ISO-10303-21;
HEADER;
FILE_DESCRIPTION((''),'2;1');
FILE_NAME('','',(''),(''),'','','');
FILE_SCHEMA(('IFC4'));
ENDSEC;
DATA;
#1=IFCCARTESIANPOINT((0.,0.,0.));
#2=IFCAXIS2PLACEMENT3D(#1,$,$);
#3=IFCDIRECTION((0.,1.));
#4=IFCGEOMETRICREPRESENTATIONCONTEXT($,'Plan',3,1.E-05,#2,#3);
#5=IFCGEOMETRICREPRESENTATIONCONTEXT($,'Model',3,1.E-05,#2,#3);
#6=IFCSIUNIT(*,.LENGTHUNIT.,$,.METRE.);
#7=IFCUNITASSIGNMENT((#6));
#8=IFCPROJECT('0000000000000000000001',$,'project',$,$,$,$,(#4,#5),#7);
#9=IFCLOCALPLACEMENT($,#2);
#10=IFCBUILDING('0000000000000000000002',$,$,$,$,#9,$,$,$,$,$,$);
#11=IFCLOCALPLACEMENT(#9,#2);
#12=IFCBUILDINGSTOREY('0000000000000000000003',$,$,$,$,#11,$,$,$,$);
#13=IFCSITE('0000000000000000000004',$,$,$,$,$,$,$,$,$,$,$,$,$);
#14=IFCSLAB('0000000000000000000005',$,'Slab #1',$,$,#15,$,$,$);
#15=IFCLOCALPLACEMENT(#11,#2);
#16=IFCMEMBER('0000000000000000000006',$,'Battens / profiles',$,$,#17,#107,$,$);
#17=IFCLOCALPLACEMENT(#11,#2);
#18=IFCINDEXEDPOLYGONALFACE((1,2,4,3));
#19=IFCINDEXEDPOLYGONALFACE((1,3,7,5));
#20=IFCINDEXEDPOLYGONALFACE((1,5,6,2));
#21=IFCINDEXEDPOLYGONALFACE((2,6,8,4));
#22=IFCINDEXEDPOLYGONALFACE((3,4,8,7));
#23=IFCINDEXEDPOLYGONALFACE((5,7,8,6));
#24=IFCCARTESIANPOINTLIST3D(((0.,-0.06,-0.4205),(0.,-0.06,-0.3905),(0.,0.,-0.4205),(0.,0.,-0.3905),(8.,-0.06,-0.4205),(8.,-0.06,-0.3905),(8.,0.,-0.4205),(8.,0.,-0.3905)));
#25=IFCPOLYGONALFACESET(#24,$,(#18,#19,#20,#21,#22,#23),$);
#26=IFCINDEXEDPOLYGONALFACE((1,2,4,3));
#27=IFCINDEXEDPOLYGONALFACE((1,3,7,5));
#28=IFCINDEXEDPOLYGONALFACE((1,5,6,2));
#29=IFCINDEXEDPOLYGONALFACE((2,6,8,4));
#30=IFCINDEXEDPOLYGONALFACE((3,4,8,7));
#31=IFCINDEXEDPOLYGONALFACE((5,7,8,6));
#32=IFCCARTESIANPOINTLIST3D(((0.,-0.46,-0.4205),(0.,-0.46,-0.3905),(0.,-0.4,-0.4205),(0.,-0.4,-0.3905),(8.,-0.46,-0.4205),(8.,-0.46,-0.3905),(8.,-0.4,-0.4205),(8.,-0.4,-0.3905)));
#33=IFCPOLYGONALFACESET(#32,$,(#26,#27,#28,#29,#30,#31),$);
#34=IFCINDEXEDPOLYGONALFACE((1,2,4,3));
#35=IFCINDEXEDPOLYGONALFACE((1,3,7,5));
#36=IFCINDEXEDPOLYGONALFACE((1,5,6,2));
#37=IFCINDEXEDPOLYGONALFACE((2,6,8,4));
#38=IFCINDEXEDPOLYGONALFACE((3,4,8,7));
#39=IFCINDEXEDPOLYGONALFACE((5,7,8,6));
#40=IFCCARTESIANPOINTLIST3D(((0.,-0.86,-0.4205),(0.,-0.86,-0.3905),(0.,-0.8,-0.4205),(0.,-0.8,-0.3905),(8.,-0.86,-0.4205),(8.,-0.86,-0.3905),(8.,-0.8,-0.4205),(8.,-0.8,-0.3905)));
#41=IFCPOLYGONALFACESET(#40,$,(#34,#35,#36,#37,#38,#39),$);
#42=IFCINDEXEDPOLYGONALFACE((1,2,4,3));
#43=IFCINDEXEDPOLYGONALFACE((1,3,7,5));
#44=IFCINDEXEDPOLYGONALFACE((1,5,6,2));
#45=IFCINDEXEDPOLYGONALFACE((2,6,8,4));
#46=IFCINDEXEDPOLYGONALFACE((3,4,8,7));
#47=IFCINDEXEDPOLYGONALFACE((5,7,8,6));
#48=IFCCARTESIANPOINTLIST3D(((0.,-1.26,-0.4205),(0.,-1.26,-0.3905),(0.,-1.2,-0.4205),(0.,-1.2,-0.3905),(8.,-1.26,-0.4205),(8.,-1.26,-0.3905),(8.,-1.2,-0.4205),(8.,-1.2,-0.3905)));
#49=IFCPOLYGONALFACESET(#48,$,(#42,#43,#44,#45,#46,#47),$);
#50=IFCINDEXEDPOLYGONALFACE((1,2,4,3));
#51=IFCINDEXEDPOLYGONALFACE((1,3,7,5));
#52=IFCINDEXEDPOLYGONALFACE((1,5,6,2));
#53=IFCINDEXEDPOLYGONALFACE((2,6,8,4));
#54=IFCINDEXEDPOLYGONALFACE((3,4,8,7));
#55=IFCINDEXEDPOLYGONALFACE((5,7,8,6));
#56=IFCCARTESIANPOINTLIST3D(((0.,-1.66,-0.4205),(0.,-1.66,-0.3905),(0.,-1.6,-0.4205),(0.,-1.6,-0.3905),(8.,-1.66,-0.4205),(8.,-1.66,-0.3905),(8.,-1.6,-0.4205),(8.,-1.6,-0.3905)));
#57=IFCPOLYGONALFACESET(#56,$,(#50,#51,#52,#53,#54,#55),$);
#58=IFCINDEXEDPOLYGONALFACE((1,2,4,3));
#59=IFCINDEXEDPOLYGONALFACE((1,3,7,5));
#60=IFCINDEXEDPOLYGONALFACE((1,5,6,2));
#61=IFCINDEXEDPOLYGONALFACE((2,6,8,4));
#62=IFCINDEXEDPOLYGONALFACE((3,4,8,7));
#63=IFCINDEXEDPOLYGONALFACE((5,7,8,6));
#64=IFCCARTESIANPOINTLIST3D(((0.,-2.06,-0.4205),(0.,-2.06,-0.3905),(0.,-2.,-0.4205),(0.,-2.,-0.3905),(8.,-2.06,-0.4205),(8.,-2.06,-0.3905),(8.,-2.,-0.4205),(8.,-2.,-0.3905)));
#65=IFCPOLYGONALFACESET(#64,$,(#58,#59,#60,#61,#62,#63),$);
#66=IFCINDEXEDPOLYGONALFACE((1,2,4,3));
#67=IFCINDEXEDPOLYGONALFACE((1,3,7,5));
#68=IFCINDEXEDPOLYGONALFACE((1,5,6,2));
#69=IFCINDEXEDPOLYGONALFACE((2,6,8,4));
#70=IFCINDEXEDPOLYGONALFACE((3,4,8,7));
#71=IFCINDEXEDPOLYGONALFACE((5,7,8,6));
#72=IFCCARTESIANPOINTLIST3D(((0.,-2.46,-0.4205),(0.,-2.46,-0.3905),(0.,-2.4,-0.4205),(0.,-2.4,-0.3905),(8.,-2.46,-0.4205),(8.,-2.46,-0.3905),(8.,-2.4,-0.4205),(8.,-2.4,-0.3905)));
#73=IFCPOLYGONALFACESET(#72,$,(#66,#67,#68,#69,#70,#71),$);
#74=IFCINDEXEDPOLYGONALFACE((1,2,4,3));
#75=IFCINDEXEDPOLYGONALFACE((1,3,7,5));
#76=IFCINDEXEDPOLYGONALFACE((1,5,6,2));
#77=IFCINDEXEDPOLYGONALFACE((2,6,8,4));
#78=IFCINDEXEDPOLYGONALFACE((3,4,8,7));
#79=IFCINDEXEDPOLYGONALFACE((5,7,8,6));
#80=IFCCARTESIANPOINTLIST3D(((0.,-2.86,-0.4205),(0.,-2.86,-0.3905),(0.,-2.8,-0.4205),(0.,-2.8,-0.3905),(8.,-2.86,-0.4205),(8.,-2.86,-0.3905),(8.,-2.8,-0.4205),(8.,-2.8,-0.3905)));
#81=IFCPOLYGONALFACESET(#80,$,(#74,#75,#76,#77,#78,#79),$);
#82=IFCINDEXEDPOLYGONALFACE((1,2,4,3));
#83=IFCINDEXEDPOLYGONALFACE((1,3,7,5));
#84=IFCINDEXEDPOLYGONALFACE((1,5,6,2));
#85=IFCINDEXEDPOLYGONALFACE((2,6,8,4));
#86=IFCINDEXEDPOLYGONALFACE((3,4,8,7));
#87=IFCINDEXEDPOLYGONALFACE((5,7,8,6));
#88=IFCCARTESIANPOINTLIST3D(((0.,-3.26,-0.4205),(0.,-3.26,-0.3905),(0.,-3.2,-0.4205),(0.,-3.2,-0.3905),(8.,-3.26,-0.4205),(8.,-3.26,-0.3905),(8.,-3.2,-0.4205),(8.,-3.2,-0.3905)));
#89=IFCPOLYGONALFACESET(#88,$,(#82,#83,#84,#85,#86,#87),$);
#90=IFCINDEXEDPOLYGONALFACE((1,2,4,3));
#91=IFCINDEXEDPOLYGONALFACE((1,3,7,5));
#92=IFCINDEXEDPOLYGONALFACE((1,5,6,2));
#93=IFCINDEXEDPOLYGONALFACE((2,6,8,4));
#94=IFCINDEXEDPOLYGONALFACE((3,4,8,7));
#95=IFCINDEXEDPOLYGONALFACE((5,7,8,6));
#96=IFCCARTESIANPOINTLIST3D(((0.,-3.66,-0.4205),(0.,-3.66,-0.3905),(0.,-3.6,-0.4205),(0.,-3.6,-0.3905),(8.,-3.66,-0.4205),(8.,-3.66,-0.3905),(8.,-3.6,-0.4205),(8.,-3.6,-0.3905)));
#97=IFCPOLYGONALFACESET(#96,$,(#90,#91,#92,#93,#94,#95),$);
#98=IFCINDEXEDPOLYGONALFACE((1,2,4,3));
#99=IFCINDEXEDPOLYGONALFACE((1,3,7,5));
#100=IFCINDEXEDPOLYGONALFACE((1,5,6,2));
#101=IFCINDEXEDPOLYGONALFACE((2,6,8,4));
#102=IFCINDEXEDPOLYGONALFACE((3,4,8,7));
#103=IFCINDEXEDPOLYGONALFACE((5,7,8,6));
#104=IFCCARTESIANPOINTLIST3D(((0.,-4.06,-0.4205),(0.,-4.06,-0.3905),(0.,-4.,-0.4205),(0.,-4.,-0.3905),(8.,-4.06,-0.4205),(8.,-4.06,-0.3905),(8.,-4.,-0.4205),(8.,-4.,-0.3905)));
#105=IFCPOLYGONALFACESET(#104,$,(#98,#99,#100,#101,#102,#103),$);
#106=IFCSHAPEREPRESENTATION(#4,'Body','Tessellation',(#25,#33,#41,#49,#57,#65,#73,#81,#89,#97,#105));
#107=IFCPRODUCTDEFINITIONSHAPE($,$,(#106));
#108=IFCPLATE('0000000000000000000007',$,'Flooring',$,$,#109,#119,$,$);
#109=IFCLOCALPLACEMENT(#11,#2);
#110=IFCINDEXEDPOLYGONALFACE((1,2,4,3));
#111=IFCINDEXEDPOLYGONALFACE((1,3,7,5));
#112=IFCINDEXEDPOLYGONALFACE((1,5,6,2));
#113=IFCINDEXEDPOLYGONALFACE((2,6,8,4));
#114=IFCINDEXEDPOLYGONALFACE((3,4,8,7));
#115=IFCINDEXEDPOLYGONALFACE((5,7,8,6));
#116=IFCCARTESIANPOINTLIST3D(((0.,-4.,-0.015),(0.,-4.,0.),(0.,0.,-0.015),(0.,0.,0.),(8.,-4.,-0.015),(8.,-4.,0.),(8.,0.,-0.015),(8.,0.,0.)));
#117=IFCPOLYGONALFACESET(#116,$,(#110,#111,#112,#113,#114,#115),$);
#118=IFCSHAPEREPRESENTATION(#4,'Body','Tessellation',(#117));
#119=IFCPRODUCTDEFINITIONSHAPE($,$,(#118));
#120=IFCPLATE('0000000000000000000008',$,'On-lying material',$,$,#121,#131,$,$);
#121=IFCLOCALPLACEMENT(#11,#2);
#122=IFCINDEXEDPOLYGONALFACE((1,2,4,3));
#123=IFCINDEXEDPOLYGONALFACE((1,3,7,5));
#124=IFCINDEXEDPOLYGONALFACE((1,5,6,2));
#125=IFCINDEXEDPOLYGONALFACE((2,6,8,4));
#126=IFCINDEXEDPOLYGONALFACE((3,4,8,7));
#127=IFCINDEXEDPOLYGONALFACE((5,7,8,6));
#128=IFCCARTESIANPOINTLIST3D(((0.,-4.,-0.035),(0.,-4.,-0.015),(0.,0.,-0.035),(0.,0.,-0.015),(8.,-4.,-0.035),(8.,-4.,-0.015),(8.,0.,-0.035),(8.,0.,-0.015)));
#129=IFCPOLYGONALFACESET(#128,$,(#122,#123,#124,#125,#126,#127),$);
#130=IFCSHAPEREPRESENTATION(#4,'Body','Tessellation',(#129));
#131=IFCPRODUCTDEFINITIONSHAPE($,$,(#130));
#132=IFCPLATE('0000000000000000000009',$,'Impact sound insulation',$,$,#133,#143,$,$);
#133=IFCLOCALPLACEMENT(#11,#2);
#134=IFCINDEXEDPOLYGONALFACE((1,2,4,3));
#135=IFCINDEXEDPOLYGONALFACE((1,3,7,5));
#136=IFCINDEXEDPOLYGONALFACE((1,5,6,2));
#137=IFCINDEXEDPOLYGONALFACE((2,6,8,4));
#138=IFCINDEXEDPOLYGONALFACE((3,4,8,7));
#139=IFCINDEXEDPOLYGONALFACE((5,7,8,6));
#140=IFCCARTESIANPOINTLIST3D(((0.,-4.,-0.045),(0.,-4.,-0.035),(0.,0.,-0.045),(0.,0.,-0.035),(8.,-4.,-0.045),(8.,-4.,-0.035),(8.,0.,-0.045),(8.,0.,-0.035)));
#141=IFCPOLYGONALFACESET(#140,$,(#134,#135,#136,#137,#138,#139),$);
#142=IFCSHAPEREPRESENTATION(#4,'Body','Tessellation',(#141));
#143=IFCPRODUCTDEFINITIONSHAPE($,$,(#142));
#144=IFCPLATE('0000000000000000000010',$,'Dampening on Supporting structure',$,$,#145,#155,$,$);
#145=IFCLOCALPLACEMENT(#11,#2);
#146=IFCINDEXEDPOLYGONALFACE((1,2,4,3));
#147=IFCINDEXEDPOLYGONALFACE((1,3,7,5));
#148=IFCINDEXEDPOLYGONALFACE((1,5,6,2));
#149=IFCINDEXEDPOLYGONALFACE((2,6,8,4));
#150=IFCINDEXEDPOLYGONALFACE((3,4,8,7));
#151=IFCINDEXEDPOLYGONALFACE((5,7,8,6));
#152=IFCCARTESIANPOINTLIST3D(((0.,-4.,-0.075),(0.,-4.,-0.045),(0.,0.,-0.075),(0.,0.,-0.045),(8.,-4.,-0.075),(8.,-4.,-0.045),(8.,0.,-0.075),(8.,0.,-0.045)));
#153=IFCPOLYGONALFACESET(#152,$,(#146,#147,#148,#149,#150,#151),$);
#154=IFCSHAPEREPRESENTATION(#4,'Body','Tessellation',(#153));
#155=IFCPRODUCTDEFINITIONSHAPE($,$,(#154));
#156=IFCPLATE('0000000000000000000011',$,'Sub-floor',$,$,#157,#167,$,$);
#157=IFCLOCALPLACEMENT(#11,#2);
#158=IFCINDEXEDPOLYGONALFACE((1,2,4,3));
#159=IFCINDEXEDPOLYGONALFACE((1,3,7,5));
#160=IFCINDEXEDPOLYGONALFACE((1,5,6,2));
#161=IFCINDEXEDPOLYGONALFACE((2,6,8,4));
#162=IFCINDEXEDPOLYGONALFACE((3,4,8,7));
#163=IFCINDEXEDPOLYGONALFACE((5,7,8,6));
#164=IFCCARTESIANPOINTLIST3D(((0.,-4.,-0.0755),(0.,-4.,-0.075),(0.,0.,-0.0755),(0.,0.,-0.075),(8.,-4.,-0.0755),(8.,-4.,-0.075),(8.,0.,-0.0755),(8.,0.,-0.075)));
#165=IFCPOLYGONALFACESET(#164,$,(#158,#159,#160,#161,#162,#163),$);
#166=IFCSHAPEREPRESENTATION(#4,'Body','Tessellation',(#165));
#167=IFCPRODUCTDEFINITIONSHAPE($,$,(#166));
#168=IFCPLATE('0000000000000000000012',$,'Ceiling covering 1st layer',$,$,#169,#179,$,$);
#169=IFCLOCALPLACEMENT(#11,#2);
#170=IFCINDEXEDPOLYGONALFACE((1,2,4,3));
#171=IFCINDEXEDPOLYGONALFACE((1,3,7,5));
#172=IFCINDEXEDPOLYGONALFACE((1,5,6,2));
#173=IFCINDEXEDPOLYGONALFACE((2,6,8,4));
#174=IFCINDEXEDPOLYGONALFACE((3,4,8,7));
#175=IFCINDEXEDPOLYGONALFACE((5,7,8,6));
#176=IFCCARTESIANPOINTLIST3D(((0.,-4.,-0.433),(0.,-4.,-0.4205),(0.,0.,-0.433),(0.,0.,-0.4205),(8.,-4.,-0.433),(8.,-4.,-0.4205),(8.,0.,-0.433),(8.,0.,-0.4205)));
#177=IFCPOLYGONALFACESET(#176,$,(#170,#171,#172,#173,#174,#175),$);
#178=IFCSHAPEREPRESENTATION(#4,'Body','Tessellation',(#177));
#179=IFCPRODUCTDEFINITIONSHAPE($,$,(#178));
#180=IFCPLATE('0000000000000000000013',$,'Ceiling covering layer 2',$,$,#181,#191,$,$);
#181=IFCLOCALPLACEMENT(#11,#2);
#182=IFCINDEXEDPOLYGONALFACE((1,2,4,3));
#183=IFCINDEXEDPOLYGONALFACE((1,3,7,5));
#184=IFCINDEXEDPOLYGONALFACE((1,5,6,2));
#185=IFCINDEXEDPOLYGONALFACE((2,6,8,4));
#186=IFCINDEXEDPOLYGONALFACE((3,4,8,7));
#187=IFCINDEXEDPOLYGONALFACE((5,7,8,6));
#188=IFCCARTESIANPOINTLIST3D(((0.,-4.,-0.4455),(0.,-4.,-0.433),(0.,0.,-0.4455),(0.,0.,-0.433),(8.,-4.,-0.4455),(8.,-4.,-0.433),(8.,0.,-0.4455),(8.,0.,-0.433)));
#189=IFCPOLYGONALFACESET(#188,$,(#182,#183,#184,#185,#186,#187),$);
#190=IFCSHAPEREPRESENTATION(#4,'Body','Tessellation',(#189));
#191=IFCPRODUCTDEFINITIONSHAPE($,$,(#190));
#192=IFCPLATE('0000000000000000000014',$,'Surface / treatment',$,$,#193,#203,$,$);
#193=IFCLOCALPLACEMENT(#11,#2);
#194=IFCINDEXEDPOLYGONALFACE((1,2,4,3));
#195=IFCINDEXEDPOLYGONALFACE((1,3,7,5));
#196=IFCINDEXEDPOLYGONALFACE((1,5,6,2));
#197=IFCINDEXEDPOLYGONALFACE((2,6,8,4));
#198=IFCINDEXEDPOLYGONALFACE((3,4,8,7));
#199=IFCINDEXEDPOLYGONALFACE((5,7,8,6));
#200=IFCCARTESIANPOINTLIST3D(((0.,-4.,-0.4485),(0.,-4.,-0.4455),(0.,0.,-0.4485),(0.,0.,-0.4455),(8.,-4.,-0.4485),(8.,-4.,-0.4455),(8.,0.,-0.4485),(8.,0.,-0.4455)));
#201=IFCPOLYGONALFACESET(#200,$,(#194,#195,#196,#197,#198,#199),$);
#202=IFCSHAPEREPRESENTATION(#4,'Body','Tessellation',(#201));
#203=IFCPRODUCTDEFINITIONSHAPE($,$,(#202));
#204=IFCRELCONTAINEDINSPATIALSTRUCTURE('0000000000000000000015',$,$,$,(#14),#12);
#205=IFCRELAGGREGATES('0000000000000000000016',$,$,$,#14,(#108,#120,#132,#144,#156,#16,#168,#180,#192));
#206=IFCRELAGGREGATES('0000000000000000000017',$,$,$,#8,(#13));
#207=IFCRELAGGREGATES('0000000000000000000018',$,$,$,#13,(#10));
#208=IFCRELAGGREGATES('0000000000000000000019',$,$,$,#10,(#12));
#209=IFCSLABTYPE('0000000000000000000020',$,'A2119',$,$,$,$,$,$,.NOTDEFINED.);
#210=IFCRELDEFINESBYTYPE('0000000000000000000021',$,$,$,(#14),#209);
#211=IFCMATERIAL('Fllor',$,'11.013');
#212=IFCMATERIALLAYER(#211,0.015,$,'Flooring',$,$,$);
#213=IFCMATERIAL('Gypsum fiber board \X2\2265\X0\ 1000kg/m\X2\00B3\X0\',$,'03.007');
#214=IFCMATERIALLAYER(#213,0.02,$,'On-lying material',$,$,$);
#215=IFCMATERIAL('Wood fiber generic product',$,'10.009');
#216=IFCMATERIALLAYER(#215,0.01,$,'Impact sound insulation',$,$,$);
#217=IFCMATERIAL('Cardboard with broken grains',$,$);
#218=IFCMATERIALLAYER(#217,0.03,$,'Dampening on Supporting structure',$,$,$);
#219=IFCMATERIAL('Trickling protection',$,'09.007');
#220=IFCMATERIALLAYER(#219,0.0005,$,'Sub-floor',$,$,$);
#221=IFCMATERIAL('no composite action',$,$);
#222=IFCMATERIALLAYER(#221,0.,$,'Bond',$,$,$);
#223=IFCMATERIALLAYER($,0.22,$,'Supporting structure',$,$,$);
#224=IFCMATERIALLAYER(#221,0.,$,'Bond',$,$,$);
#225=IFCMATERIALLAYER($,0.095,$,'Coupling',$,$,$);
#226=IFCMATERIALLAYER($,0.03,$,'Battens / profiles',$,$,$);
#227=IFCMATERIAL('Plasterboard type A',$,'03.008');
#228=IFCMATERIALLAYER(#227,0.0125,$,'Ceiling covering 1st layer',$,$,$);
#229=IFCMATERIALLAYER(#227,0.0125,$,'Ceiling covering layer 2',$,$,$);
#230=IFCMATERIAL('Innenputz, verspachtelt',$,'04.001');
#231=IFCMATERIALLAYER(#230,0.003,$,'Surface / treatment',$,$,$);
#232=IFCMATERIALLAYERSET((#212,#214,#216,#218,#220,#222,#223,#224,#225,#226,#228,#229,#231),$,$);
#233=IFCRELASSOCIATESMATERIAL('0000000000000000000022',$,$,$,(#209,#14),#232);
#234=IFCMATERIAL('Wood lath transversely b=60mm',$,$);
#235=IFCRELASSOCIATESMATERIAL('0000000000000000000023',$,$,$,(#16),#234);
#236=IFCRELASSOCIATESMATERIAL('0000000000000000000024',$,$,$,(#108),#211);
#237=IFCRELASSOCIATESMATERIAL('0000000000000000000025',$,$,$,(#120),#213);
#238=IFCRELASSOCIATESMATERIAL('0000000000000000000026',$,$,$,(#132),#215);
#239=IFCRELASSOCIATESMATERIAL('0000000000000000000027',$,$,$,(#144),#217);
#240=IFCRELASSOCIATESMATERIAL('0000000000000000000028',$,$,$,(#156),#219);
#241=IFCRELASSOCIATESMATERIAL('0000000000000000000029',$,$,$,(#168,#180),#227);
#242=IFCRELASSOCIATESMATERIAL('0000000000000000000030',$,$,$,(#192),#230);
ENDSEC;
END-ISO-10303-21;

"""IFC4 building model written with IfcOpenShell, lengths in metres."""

from ifc_helpers import new_model, si_unit, direction, frame, frame_2d, origin, origin_with_axes, place, context, project, spatial, rectangle, extrude, material, layer, layer_set, type_object, element, aggregate, save


model = new_model("IFC4")

# Units and contexts
plan_context = context("Plan", 3, precision=1e-05, world=origin(), true_north=direction((0.0, 1.0)))
model_context = context("Model", 3, precision=1e-05, world=origin(), true_north=direction((0.0, 1.0)))
ifc_project = project(units=[si_unit("LENGTHUNIT", "METRE")], contexts=[plan_context, model_context])

# Site, building, storey
site = spatial("IfcSite", under=ifc_project)
building_placement = place(None, origin())
building = spatial("IfcBuilding", under=site, at=building_placement)
storey_placement = place(building_placement, origin())
storey = spatial("IfcBuildingStorey", under=building, at=storey_placement)

# Slab, member, plates
ifc_material_1 = material(Name="Fllor", Category="11.013")
ifc_layer_1 = layer(ifc_material_1, 0.015, Name="Flooring")
ifc_material_2 = material(Name="Gypsum fiber board ≥ 1000kg/m³", Category="03.007")
ifc_layer_2 = layer(ifc_material_2, 0.02, Name="On-lying material")
ifc_material_3 = material(Name="Wood fiber generic product", Category="10.009")
ifc_layer_3 = layer(ifc_material_3, 0.01, Name="Impact sound insulation")
ifc_material_4 = material(Name="Cardboard with broken grains")
ifc_layer_4 = layer(ifc_material_4, 0.03, Name="Dampening on Supporting structure")
ifc_material_5 = material(Name="Trickling protection", Category="09.007")
ifc_layer_5 = layer(ifc_material_5, 0.0005, Name="Sub-floor")
ifc_material_6 = material(Name="no composite action")
ifc_layer_6 = layer(ifc_material_6, 0.0, Name="Bond")
ifc_layer_7 = layer(None, 0.22, Name="Supporting structure")
ifc_layer_8 = layer(ifc_material_6, 0.0, Name="Bond")
ifc_layer_9 = layer(None, 0.095, Name="Coupling")
ifc_layer_10 = layer(None, 0.03, Name="Battens / profiles")
ifc_material_7 = material(Name="Plasterboard type A", Category="03.008")
ifc_layer_11 = layer(ifc_material_7, 0.0125, Name="Ceiling covering 1st layer")
ifc_layer_12 = layer(ifc_material_7, 0.0125, Name="Ceiling covering layer 2")
ifc_material_8 = material(Name="Innenputz, verspachtelt", Category="04.001")
ifc_layer_13 = layer(ifc_material_8, 0.003, Name="Surface / treatment")
ifc_layer_set = layer_set([ifc_layer_1, ifc_layer_2, ifc_layer_3, ifc_layer_4, ifc_layer_5, ifc_layer_6, ifc_layer_7, ifc_layer_8, ifc_layer_9, ifc_layer_10, ifc_layer_11, ifc_layer_12, ifc_layer_13])
slab_type = type_object("IfcSlabType", Name="A2119", PredefinedType="NOTDEFINED", material=ifc_layer_set)
slab_placement = place(None, frame((0.0, 0.0, 0.0), z_axis=(0.0, 0.0, -1.0), x_axis=(1.0, 0.0, 0.0)))
slab = element("IfcSlab", 1, at=slab_placement, inside=storey, type_object=slab_type, material=ifc_layer_set, Name="Slab #1")
ifc_material_9 = material(Name="Wood lath transversely b=60mm")
member_1_placement = place(slab_placement, origin())
member_1 = element("IfcMember", 2, at=member_1_placement, material=ifc_material_9, Name="Battens / profiles", context=plan_context, shape_type="SweptSolid", body=[
    extrude(rectangle(XDim=0.06, YDim=0.03, at=frame_2d((0.03, 0.015), x_axis=(1.0, 0.0))), frame((0.0, 0.0, 0.3905), z_axis=(1.0, 0.0, 0.0), x_axis=(0.0, 1.0, 0.0)), (0.0, 0.0, 1.0), 8.0),
    extrude(rectangle(XDim=0.06, YDim=0.03, at=frame_2d((0.03, 0.015), x_axis=(1.0, 0.0))), frame((0.0, 0.4, 0.3905), z_axis=(1.0, 0.0, 0.0), x_axis=(0.0, 1.0, 0.0)), (0.0, 0.0, 1.0), 8.0),
    extrude(rectangle(XDim=0.06, YDim=0.03, at=frame_2d((0.03, 0.015), x_axis=(1.0, 0.0))), frame((0.0, 0.8, 0.3905), z_axis=(1.0, 0.0, 0.0), x_axis=(0.0, 1.0, 0.0)), (0.0, 0.0, 1.0), 8.0),
    extrude(rectangle(XDim=0.06, YDim=0.03, at=frame_2d((0.03, 0.015), x_axis=(1.0, 0.0))), frame((0.0, 1.2, 0.3905), z_axis=(1.0, 0.0, 0.0), x_axis=(0.0, 1.0, 0.0)), (0.0, 0.0, 1.0), 8.0),
    extrude(rectangle(XDim=0.06, YDim=0.03, at=frame_2d((0.03, 0.015), x_axis=(1.0, 0.0))), frame((0.0, 1.6, 0.3905), z_axis=(1.0, 0.0, 0.0), x_axis=(0.0, 1.0, 0.0)), (0.0, 0.0, 1.0), 8.0),
    extrude(rectangle(XDim=0.06, YDim=0.03, at=frame_2d((0.03, 0.015), x_axis=(1.0, 0.0))), frame((0.0, 2.0, 0.3905), z_axis=(1.0, 0.0, 0.0), x_axis=(0.0, 1.0, 0.0)), (0.0, 0.0, 1.0), 8.0),
    extrude(rectangle(XDim=0.06, YDim=0.03, at=frame_2d((0.03, 0.015), x_axis=(1.0, 0.0))), frame((0.0, 2.4, 0.3905), z_axis=(1.0, 0.0, 0.0), x_axis=(0.0, 1.0, 0.0)), (0.0, 0.0, 1.0), 8.0),
    extrude(rectangle(XDim=0.06, YDim=0.03, at=frame_2d((0.03, 0.015), x_axis=(1.0, 0.0))), frame((0.0, 2.8, 0.3905), z_axis=(1.0, 0.0, 0.0), x_axis=(0.0, 1.0, 0.0)), (0.0, 0.0, 1.0), 8.0),
    extrude(rectangle(XDim=0.06, YDim=0.03, at=frame_2d((0.03, 0.015), x_axis=(1.0, 0.0))), frame((0.0, 3.2, 0.3905), z_axis=(1.0, 0.0, 0.0), x_axis=(0.0, 1.0, 0.0)), (0.0, 0.0, 1.0), 8.0),
    extrude(rectangle(XDim=0.06, YDim=0.03, at=frame_2d((0.03, 0.015), x_axis=(1.0, 0.0))), frame((0.0, 3.6, 0.3905), z_axis=(1.0, 0.0, 0.0), x_axis=(0.0, 1.0, 0.0)), (0.0, 0.0, 1.0), 8.0),
    extrude(rectangle(XDim=0.06, YDim=0.03, at=frame_2d((0.03, 0.015), x_axis=(1.0, 0.0))), frame((0.0, 4.0, 0.3905), z_axis=(1.0, 0.0, 0.0), x_axis=(0.0, 1.0, 0.0)), (0.0, 0.0, 1.0), 8.0),
])
plate_1_placement = place(slab_placement, origin())
plate_1 = element("IfcPlate", 3, at=plate_1_placement, material=ifc_material_1, Name="Flooring", context=plan_context, shape_type="SweptSolid", body=[
    extrude(rectangle(XDim=8.0, YDim=4.0, at=frame_2d((4.0, 2.0), x_axis=(1.0, 0.0))), origin_with_axes(), (0.0, 0.0, 1.0), 0.015),
])
plate_2_placement = place(slab_placement, origin())
plate_2 = element("IfcPlate", 4, at=plate_2_placement, material=ifc_material_2, Name="On-lying material", context=plan_context, shape_type="SweptSolid", body=[
    extrude(rectangle(XDim=8.0, YDim=4.0, at=frame_2d((4.0, 2.0), x_axis=(1.0, 0.0))), frame((0.0, 0.0, 0.015), z_axis=(0.0, 0.0, 1.0), x_axis=(1.0, 0.0, 0.0)), (0.0, 0.0, 1.0), 0.02),
])
plate_3_placement = place(slab_placement, origin())
plate_3 = element("IfcPlate", 5, at=plate_3_placement, material=ifc_material_3, Name="Impact sound insulation", context=plan_context, shape_type="SweptSolid", body=[
    extrude(rectangle(XDim=8.0, YDim=4.0, at=frame_2d((4.0, 2.0), x_axis=(1.0, 0.0))), frame((0.0, 0.0, 0.035), z_axis=(0.0, 0.0, 1.0), x_axis=(1.0, 0.0, 0.0)), (0.0, 0.0, 1.0), 0.01),
])
plate_4_placement = place(slab_placement, origin())
plate_4 = element("IfcPlate", 6, at=plate_4_placement, material=ifc_material_4, Name="Dampening on Supporting structure", context=plan_context, shape_type="SweptSolid", body=[
    extrude(rectangle(XDim=8.0, YDim=4.0, at=frame_2d((4.0, 2.0), x_axis=(1.0, 0.0))), frame((0.0, 0.0, 0.045), z_axis=(0.0, 0.0, 1.0), x_axis=(1.0, 0.0, 0.0)), (0.0, 0.0, 1.0), 0.03),
])
plate_5_placement = place(slab_placement, origin())
plate_5 = element("IfcPlate", 7, at=plate_5_placement, material=ifc_material_5, Name="Sub-floor", context=plan_context, shape_type="SweptSolid", body=[
    extrude(rectangle(XDim=8.0, YDim=4.0, at=frame_2d((4.0, 2.0), x_axis=(1.0, 0.0))), frame((0.0, 0.0, 0.075), z_axis=(0.0, 0.0, 1.0), x_axis=(1.0, 0.0, 0.0)), (0.0, 0.0, 1.0), 0.0005),
])
plate_6_placement = place(slab_placement, origin())
plate_6 = element("IfcPlate", 8, at=plate_6_placement, material=ifc_material_7, Name="Ceiling covering 1st layer", context=plan_context, shape_type="SweptSolid", body=[
    extrude(rectangle(XDim=8.0, YDim=4.0, at=frame_2d((4.0, 2.0), x_axis=(1.0, 0.0))), frame((0.0, 0.0, 0.4205), z_axis=(0.0, 0.0, 1.0), x_axis=(1.0, 0.0, 0.0)), (0.0, 0.0, 1.0), 0.0125),
])
plate_7_placement = place(slab_placement, origin())
plate_7 = element("IfcPlate", 9, at=plate_7_placement, material=ifc_material_7, Name="Ceiling covering layer 2", context=plan_context, shape_type="SweptSolid", body=[
    extrude(rectangle(XDim=8.0, YDim=4.0, at=frame_2d((4.0, 2.0), x_axis=(1.0, 0.0))), frame((0.0, 0.0, 0.433), z_axis=(0.0, 0.0, 1.0), x_axis=(1.0, 0.0, 0.0)), (0.0, 0.0, 1.0), 0.0125),
])
plate_8_placement = place(slab_placement, origin())
plate_8 = element("IfcPlate", 10, at=plate_8_placement, material=ifc_material_8, Name="Surface / treatment", context=plan_context, shape_type="SweptSolid", body=[
    extrude(rectangle(XDim=8.0, YDim=4.0, at=frame_2d((4.0, 2.0), x_axis=(1.0, 0.0))), frame((0.0, 0.0, 0.4455), z_axis=(0.0, 0.0, 1.0), x_axis=(1.0, 0.0, 0.0)), (0.0, 0.0, 1.0), 0.003),
])
aggregate(slab, [plate_1, plate_2, plate_3, plate_4, plate_5, member_1, plate_6, plate_7, plate_8])

save(model, "model.ifc")
